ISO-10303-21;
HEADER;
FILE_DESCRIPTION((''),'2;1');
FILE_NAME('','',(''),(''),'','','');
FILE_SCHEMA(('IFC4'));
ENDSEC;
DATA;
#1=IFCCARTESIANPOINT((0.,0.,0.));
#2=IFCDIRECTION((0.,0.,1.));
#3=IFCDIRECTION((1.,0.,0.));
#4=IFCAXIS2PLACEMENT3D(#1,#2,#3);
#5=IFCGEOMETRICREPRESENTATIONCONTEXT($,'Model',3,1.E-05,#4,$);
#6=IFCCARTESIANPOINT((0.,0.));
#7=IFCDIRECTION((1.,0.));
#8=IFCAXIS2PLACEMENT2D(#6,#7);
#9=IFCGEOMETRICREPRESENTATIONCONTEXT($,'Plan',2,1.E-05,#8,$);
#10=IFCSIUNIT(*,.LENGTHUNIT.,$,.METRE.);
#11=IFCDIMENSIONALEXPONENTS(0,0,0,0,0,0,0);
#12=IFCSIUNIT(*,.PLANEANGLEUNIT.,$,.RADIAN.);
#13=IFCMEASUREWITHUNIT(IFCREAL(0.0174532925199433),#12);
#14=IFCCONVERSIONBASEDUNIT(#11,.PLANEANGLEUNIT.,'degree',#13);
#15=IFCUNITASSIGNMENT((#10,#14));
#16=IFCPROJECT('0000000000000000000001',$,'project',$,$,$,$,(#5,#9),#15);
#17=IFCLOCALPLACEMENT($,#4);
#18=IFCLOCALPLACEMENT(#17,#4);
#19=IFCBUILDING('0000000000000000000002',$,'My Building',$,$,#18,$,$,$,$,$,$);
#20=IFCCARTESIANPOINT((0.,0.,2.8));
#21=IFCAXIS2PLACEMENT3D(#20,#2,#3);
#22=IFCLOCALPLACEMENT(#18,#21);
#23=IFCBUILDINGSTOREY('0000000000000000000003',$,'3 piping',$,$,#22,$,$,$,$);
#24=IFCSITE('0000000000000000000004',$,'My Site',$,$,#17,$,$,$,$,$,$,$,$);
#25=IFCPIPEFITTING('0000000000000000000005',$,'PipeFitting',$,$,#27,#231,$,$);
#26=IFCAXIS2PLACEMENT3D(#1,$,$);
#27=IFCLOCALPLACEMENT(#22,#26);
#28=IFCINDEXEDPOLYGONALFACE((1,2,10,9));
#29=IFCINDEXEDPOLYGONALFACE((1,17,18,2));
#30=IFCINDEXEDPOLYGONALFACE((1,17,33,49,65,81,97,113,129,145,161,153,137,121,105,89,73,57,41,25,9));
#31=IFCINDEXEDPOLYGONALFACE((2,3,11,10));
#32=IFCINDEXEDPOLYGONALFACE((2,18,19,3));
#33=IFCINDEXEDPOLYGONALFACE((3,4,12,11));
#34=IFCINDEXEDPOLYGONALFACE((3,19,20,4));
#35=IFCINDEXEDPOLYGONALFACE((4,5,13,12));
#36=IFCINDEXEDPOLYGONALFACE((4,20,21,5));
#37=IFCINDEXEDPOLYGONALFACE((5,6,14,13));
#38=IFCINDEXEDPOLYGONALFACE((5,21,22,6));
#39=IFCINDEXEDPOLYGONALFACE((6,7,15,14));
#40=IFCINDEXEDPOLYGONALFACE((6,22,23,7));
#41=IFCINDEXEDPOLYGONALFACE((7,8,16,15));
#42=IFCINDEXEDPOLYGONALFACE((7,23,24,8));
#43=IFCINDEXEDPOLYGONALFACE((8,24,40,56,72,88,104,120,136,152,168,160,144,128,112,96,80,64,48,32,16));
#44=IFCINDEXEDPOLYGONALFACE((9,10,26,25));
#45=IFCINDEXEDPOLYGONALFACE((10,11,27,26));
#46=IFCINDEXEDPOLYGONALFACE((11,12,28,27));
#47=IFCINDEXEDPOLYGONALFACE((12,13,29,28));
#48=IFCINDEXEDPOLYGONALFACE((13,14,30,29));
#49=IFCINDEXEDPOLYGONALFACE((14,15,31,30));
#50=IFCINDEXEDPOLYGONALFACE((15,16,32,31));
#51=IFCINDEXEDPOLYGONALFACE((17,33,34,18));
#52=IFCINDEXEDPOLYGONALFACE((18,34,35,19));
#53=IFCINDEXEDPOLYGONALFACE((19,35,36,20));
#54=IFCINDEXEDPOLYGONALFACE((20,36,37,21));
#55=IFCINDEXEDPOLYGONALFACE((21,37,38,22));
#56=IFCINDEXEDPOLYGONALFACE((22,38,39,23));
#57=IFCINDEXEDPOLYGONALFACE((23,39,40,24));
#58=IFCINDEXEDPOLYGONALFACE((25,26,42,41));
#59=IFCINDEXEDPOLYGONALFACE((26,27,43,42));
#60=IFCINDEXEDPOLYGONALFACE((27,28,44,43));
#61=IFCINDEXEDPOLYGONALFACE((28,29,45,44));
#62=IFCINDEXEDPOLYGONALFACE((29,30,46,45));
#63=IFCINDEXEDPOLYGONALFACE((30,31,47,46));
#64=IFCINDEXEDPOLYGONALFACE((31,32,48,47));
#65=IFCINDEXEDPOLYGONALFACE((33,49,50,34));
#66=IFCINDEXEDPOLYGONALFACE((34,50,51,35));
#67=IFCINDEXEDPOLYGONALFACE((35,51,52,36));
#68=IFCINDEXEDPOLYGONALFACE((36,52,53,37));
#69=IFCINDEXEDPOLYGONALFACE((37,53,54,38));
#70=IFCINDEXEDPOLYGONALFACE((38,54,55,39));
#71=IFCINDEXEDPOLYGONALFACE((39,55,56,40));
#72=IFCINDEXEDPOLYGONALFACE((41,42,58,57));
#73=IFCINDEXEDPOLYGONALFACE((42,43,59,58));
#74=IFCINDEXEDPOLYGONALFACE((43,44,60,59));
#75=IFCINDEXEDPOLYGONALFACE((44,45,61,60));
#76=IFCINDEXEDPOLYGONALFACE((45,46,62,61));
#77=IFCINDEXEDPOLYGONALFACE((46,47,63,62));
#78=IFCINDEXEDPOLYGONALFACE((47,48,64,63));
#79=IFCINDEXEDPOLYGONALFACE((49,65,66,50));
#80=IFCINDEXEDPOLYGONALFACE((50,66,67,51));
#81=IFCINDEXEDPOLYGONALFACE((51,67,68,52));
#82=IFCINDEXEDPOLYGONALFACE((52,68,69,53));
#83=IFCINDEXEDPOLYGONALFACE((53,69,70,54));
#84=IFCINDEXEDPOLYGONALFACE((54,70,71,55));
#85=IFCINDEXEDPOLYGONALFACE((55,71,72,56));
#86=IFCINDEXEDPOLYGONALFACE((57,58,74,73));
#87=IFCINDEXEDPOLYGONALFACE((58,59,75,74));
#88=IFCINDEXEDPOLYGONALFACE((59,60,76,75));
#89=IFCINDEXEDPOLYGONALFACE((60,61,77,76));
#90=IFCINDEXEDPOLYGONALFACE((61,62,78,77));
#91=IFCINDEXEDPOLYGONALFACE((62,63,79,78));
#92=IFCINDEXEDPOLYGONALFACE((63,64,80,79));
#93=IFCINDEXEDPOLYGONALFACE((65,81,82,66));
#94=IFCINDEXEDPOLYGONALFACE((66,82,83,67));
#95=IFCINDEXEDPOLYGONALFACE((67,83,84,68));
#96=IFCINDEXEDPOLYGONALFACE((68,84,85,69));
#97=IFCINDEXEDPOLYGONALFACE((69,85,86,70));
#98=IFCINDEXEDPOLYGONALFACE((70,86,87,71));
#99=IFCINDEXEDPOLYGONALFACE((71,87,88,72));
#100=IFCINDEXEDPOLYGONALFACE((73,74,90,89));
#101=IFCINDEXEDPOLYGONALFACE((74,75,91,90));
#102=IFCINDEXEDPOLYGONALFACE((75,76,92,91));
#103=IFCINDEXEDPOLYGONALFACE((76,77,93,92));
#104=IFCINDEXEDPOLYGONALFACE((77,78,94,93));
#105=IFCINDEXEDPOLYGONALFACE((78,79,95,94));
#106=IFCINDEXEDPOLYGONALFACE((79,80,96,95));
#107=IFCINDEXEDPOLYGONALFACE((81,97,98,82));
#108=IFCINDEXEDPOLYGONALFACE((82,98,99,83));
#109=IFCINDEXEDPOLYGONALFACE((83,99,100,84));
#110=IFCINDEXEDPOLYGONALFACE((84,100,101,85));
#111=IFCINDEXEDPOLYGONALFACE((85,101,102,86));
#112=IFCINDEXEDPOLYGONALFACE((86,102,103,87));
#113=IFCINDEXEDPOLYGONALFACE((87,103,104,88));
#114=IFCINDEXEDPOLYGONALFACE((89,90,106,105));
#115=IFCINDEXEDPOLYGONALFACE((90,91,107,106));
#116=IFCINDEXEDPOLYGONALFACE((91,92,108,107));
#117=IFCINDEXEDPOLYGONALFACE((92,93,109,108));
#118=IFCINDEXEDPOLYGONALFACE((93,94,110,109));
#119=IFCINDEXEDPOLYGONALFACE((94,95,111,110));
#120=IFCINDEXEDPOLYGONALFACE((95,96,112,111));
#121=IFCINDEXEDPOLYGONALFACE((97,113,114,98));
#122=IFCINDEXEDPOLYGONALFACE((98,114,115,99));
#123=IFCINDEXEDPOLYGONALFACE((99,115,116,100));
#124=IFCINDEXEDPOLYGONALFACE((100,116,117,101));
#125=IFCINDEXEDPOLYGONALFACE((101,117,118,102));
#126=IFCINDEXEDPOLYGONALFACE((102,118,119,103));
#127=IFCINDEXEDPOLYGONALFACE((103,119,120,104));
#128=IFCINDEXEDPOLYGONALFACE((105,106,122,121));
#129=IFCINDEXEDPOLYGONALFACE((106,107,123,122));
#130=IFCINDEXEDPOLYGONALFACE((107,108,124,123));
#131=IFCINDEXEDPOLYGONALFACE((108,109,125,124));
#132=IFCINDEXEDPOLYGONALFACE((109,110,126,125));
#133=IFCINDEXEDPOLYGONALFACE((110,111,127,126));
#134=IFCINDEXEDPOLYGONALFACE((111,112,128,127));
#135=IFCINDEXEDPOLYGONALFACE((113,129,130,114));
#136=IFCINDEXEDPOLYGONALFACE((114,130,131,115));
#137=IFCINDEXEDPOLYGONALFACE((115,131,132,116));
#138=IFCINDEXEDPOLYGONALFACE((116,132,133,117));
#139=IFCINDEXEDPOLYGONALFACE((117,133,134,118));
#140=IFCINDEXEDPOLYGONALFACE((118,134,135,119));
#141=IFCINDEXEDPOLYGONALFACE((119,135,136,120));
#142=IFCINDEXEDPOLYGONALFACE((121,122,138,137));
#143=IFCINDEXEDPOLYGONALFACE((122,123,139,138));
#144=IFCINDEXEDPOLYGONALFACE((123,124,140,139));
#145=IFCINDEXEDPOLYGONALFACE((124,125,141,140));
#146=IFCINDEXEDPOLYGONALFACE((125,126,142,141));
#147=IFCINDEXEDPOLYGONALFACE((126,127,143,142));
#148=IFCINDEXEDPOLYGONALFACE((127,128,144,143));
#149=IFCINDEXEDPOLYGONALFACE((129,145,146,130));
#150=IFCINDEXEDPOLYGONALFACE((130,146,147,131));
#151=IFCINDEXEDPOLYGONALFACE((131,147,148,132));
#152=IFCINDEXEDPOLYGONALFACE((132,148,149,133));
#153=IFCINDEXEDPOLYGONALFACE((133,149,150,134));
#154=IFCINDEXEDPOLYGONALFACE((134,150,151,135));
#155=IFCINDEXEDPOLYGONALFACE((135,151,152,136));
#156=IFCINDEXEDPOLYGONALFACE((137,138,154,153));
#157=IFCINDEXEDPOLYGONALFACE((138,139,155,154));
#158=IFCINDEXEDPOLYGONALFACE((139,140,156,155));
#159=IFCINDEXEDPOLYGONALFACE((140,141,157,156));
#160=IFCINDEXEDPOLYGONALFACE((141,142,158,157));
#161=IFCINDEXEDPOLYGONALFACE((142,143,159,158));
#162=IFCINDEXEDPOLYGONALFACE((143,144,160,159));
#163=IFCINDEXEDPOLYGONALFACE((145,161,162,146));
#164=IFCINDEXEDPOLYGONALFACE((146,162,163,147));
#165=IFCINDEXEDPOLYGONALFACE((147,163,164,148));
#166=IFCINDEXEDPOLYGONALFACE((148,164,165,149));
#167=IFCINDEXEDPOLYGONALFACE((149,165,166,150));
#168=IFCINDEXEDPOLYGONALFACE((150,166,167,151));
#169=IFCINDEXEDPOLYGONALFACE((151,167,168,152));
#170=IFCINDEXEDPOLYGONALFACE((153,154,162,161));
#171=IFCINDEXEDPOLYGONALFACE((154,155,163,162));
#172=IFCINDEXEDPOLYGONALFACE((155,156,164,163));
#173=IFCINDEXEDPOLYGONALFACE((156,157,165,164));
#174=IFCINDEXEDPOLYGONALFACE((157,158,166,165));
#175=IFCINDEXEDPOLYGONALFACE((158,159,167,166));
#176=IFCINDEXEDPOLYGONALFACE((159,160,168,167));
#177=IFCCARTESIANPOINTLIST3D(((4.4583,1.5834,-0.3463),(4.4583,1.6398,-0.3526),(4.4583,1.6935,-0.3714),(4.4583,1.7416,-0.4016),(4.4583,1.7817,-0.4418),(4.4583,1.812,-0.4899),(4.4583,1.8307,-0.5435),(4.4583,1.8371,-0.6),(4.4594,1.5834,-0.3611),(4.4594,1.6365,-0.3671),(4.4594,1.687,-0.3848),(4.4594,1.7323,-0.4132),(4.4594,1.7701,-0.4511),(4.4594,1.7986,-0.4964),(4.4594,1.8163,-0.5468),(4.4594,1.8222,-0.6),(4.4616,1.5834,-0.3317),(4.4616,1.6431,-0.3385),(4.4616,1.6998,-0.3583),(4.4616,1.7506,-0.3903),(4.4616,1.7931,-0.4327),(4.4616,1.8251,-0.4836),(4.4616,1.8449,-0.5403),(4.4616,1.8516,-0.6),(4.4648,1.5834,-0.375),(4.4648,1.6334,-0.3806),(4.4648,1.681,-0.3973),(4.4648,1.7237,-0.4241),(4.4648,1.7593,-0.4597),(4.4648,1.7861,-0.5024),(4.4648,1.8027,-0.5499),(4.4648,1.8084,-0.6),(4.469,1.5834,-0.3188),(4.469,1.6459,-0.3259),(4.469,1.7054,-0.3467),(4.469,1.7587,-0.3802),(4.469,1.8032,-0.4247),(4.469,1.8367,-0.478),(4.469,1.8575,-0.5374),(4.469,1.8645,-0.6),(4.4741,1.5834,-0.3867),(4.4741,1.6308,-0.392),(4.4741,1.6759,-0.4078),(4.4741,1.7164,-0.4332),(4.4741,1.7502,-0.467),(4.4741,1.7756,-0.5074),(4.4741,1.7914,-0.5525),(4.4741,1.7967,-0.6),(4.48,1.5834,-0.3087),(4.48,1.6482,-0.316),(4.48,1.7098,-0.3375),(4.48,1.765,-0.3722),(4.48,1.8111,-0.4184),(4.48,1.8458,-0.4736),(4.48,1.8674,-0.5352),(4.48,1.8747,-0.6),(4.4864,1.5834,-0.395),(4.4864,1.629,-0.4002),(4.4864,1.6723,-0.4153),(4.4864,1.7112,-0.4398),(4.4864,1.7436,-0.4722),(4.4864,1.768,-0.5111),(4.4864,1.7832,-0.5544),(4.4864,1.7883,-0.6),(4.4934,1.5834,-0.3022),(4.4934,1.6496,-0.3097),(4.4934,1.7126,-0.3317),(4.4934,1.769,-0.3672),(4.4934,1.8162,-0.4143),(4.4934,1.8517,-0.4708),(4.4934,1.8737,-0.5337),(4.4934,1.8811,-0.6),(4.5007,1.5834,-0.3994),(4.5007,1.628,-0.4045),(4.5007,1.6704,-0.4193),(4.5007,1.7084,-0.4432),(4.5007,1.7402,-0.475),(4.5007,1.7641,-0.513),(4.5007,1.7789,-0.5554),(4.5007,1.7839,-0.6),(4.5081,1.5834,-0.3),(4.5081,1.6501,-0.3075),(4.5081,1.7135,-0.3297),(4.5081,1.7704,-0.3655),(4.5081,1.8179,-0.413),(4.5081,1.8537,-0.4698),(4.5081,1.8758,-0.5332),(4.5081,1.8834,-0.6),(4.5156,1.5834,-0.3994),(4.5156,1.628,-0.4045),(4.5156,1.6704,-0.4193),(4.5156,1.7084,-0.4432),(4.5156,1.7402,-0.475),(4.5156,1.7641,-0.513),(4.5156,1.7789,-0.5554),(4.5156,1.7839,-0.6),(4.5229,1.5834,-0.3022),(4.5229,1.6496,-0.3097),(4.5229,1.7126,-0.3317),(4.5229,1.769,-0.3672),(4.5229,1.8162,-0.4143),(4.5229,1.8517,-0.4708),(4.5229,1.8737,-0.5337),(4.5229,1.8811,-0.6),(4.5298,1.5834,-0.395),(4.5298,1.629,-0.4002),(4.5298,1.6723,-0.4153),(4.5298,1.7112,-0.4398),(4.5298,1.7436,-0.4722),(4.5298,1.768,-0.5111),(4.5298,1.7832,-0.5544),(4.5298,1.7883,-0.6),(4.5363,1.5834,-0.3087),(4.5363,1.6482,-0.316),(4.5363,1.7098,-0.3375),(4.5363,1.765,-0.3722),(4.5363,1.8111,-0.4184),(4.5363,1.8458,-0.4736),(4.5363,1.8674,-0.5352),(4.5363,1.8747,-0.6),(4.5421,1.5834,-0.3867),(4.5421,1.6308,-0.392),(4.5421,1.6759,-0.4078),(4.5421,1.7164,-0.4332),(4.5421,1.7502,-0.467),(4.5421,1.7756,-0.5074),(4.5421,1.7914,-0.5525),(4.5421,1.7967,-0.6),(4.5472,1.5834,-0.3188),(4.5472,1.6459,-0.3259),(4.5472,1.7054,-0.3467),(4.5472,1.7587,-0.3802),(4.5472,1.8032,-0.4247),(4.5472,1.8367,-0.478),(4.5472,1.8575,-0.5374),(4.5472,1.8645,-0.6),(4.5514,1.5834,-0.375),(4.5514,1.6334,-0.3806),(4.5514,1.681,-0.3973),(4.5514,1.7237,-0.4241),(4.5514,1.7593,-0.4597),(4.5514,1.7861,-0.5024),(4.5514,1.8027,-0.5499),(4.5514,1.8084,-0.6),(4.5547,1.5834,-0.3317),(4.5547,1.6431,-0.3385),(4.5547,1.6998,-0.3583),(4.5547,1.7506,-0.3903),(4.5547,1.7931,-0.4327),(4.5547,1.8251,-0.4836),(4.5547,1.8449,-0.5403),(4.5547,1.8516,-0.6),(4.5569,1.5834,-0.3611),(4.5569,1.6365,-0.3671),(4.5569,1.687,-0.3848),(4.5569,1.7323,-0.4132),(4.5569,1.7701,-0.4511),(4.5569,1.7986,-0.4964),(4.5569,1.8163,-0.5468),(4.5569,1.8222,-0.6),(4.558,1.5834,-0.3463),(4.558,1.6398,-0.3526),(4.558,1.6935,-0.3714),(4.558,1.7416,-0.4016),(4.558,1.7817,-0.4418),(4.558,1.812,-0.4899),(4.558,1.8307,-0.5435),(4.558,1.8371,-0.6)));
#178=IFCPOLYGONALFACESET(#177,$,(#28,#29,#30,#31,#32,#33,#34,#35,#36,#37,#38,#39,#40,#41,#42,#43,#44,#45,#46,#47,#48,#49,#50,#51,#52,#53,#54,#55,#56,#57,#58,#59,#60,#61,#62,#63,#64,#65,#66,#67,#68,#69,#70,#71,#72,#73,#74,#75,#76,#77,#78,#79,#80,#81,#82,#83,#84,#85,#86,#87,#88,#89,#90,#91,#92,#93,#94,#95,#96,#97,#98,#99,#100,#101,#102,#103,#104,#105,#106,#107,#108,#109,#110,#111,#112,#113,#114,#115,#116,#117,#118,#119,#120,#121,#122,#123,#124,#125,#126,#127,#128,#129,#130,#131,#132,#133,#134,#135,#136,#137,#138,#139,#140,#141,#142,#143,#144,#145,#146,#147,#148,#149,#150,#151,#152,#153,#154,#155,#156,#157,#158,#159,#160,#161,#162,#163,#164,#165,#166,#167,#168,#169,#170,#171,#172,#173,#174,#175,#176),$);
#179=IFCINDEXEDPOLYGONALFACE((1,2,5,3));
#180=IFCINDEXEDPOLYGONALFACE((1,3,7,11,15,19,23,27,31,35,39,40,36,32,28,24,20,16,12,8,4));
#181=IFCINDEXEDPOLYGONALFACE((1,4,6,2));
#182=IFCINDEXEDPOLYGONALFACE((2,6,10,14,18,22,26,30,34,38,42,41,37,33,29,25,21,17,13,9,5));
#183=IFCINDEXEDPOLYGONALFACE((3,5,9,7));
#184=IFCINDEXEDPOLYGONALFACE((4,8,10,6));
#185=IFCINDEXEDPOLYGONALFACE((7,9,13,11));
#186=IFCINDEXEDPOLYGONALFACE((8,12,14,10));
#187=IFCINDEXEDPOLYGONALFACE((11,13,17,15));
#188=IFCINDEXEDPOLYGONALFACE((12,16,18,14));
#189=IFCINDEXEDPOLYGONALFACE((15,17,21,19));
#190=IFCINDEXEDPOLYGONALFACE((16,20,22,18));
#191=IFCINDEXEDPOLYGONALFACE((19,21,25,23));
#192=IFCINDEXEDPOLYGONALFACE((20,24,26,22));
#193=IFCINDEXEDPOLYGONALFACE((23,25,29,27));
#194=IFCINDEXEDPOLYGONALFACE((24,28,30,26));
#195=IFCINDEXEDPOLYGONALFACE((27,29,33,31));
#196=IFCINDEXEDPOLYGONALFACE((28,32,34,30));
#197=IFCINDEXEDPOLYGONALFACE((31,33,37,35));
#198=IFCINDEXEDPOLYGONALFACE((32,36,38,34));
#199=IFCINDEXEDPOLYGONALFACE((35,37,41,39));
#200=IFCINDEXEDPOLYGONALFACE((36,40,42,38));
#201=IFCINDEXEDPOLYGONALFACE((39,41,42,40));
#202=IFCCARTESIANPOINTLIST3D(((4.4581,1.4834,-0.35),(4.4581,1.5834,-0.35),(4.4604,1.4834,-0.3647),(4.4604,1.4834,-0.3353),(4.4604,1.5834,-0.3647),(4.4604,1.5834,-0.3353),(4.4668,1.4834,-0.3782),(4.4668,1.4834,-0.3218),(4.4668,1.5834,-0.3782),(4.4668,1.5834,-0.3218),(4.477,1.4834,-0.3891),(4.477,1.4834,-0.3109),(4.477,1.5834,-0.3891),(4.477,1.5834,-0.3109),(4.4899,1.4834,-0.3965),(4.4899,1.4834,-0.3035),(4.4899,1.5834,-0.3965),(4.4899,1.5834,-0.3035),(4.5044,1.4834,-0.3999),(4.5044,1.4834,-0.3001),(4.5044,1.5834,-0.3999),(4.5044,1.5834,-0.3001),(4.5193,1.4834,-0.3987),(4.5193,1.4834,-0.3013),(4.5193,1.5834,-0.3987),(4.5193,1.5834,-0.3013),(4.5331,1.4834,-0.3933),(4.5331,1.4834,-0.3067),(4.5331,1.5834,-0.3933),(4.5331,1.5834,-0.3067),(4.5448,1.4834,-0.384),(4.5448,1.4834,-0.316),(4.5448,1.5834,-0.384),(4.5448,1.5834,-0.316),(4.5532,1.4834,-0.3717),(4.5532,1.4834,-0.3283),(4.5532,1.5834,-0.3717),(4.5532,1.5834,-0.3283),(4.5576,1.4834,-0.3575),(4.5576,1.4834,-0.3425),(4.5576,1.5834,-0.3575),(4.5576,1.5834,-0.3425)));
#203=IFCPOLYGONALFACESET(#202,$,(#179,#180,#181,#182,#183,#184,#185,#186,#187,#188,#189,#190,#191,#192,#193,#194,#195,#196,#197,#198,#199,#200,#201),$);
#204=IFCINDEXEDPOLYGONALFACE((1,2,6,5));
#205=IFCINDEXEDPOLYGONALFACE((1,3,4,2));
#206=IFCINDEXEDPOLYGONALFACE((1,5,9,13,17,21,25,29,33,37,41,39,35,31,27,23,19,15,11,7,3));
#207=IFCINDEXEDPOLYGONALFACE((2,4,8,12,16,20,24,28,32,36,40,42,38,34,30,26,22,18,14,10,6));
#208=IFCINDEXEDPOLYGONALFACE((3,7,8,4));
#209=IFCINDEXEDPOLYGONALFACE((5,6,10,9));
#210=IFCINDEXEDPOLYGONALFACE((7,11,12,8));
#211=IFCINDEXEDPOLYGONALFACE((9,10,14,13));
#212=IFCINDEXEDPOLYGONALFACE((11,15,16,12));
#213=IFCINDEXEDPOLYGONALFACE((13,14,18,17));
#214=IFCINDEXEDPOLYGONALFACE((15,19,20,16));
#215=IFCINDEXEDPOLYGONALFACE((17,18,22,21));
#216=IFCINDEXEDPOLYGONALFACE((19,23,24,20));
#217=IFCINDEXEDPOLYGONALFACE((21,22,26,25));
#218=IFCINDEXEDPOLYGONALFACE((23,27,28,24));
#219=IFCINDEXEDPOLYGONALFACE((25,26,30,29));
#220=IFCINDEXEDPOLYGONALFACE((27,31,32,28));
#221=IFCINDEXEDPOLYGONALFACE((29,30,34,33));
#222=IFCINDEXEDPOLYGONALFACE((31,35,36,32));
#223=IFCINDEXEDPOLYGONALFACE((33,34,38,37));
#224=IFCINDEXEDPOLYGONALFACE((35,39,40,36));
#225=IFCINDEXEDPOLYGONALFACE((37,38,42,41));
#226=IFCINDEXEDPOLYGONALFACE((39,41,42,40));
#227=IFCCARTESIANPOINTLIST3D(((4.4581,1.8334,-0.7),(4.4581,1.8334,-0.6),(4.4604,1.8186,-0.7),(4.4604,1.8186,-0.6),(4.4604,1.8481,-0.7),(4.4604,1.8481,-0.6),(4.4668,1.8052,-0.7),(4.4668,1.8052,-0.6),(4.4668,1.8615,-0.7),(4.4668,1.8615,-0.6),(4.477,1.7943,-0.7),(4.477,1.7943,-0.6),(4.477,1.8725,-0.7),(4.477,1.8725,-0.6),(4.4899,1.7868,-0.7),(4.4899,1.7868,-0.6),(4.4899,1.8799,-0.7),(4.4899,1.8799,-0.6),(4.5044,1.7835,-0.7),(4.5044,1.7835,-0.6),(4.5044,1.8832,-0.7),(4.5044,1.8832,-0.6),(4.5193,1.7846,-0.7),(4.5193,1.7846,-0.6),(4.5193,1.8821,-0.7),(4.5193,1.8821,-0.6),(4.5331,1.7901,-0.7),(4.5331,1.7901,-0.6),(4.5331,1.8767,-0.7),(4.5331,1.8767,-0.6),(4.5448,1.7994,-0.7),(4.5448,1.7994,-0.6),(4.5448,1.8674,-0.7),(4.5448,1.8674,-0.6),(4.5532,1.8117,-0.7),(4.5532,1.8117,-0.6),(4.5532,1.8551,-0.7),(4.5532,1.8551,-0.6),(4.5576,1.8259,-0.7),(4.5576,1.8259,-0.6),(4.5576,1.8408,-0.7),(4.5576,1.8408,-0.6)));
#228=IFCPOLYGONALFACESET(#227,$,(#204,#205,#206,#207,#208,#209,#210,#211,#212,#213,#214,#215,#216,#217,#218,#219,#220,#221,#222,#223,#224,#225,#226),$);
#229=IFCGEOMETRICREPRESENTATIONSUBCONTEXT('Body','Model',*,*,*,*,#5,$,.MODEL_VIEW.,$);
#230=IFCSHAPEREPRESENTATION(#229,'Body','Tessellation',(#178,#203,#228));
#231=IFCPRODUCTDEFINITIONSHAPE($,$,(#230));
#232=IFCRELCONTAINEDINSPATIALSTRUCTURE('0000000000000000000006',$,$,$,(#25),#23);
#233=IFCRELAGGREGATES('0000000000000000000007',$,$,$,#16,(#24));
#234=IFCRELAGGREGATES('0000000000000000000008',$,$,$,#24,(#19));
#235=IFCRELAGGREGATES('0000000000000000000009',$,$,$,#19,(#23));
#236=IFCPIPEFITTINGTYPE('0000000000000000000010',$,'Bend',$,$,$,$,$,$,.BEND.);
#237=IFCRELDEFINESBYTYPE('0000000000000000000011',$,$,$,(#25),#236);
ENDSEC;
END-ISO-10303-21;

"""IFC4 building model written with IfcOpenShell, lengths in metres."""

from ifc_helpers import new_model, entity, si_unit, converted_unit, frame, origin_with_axes, origin_2d_with_axis, place, context, subcontext, project, spatial, circle, extrude, source, transform, mapped, type_object, type_shapes, element, save


model = new_model("IFC4")

# Units and contexts
model_context = context("Model", 3, precision=1e-05, world=origin_with_axes())
plan_context = context("Plan", 2, precision=1e-05, world=origin_2d_with_axis())
body_context = subcontext(model_context, "Body", "Model", "MODEL_VIEW")
ifc_project = project(units=[si_unit("LENGTHUNIT", "METRE"), converted_unit("PLANEANGLEUNIT", "degree", entity("IfcReal", 0.0174532925199433), si_unit("PLANEANGLEUNIT", "RADIAN"), dimensions=[0, 0, 0, 0, 0, 0, 0])], contexts=[model_context, plan_context])

# Site, building, storey
site_placement = place(None, origin_with_axes())
site = spatial("IfcSite", under=ifc_project, at=site_placement, Name="My Site")
building_placement = place(site_placement, origin_with_axes())
building = spatial("IfcBuilding", under=site, at=building_placement, Name="My Building")
storey_placement = place(building_placement, frame((0.0, 0.0, 2.8), z_axis=(0.0, 0.0, 1.0), x_axis=(1.0, 0.0, 0.0)))
storey = spatial("IfcBuildingStorey", under=building, at=storey_placement, Name="3 piping")

# Pipe fitting
pipe_fitting_type_1 = type_object("IfcPipeFittingType", Name="Bend", PredefinedType="BEND")
shared_shape = source(origin_with_axes(), body_context, "Body", "SolidModel", [
    entity("IfcSweptDiskSolid", entity("IfcIndexedPolyCurve", entity("IfcCartesianPointList3D", [[0.0, 0.0, 0.1], [0.0, -0.0732, 0.2768], [0.0, -0.25, 0.35]]), [entity("IfcArcIndex", [1, 2, 3])]), 0.05),
    extrude(circle(Radius=0.05), origin_with_axes(), (0.0, 0.0, 1.0), 0.1),
    extrude(circle(Radius=0.05), frame((0.0, -0.25, 0.35), z_axis=(0.0, -1.0, 0.0), x_axis=(1.0, 0.0, 0.0)), (0.0, 0.0, 1.0), 0.1),
])
type_shapes(pipe_fitting_type_1, [shared_shape])
for number, where, z_axis, x_axis, name in (
    (1, (4.5081, 1.4834, -0.35), (0.0, 1.0, 0.0), (-1.0, 0.0, 0.0), "PipeFitting"),
):
    element("IfcPipeFitting", number, at=place(storey_placement, frame(where, z_axis=z_axis, x_axis=x_axis)), inside=storey, type_object=pipe_fitting_type_1, Name=name, context=body_context, shape_type="MappedRepresentation", body=[
        mapped(shared_shape, transform((0.0, 0.0, 0.0), x_axis=(1.0, 0.0, 0.0), y_axis=(0.0, 1.0, 0.0), z_axis=(0.0, 0.0, 1.0), scale=1.0)),
    ])

save(model, "model.ifc")
